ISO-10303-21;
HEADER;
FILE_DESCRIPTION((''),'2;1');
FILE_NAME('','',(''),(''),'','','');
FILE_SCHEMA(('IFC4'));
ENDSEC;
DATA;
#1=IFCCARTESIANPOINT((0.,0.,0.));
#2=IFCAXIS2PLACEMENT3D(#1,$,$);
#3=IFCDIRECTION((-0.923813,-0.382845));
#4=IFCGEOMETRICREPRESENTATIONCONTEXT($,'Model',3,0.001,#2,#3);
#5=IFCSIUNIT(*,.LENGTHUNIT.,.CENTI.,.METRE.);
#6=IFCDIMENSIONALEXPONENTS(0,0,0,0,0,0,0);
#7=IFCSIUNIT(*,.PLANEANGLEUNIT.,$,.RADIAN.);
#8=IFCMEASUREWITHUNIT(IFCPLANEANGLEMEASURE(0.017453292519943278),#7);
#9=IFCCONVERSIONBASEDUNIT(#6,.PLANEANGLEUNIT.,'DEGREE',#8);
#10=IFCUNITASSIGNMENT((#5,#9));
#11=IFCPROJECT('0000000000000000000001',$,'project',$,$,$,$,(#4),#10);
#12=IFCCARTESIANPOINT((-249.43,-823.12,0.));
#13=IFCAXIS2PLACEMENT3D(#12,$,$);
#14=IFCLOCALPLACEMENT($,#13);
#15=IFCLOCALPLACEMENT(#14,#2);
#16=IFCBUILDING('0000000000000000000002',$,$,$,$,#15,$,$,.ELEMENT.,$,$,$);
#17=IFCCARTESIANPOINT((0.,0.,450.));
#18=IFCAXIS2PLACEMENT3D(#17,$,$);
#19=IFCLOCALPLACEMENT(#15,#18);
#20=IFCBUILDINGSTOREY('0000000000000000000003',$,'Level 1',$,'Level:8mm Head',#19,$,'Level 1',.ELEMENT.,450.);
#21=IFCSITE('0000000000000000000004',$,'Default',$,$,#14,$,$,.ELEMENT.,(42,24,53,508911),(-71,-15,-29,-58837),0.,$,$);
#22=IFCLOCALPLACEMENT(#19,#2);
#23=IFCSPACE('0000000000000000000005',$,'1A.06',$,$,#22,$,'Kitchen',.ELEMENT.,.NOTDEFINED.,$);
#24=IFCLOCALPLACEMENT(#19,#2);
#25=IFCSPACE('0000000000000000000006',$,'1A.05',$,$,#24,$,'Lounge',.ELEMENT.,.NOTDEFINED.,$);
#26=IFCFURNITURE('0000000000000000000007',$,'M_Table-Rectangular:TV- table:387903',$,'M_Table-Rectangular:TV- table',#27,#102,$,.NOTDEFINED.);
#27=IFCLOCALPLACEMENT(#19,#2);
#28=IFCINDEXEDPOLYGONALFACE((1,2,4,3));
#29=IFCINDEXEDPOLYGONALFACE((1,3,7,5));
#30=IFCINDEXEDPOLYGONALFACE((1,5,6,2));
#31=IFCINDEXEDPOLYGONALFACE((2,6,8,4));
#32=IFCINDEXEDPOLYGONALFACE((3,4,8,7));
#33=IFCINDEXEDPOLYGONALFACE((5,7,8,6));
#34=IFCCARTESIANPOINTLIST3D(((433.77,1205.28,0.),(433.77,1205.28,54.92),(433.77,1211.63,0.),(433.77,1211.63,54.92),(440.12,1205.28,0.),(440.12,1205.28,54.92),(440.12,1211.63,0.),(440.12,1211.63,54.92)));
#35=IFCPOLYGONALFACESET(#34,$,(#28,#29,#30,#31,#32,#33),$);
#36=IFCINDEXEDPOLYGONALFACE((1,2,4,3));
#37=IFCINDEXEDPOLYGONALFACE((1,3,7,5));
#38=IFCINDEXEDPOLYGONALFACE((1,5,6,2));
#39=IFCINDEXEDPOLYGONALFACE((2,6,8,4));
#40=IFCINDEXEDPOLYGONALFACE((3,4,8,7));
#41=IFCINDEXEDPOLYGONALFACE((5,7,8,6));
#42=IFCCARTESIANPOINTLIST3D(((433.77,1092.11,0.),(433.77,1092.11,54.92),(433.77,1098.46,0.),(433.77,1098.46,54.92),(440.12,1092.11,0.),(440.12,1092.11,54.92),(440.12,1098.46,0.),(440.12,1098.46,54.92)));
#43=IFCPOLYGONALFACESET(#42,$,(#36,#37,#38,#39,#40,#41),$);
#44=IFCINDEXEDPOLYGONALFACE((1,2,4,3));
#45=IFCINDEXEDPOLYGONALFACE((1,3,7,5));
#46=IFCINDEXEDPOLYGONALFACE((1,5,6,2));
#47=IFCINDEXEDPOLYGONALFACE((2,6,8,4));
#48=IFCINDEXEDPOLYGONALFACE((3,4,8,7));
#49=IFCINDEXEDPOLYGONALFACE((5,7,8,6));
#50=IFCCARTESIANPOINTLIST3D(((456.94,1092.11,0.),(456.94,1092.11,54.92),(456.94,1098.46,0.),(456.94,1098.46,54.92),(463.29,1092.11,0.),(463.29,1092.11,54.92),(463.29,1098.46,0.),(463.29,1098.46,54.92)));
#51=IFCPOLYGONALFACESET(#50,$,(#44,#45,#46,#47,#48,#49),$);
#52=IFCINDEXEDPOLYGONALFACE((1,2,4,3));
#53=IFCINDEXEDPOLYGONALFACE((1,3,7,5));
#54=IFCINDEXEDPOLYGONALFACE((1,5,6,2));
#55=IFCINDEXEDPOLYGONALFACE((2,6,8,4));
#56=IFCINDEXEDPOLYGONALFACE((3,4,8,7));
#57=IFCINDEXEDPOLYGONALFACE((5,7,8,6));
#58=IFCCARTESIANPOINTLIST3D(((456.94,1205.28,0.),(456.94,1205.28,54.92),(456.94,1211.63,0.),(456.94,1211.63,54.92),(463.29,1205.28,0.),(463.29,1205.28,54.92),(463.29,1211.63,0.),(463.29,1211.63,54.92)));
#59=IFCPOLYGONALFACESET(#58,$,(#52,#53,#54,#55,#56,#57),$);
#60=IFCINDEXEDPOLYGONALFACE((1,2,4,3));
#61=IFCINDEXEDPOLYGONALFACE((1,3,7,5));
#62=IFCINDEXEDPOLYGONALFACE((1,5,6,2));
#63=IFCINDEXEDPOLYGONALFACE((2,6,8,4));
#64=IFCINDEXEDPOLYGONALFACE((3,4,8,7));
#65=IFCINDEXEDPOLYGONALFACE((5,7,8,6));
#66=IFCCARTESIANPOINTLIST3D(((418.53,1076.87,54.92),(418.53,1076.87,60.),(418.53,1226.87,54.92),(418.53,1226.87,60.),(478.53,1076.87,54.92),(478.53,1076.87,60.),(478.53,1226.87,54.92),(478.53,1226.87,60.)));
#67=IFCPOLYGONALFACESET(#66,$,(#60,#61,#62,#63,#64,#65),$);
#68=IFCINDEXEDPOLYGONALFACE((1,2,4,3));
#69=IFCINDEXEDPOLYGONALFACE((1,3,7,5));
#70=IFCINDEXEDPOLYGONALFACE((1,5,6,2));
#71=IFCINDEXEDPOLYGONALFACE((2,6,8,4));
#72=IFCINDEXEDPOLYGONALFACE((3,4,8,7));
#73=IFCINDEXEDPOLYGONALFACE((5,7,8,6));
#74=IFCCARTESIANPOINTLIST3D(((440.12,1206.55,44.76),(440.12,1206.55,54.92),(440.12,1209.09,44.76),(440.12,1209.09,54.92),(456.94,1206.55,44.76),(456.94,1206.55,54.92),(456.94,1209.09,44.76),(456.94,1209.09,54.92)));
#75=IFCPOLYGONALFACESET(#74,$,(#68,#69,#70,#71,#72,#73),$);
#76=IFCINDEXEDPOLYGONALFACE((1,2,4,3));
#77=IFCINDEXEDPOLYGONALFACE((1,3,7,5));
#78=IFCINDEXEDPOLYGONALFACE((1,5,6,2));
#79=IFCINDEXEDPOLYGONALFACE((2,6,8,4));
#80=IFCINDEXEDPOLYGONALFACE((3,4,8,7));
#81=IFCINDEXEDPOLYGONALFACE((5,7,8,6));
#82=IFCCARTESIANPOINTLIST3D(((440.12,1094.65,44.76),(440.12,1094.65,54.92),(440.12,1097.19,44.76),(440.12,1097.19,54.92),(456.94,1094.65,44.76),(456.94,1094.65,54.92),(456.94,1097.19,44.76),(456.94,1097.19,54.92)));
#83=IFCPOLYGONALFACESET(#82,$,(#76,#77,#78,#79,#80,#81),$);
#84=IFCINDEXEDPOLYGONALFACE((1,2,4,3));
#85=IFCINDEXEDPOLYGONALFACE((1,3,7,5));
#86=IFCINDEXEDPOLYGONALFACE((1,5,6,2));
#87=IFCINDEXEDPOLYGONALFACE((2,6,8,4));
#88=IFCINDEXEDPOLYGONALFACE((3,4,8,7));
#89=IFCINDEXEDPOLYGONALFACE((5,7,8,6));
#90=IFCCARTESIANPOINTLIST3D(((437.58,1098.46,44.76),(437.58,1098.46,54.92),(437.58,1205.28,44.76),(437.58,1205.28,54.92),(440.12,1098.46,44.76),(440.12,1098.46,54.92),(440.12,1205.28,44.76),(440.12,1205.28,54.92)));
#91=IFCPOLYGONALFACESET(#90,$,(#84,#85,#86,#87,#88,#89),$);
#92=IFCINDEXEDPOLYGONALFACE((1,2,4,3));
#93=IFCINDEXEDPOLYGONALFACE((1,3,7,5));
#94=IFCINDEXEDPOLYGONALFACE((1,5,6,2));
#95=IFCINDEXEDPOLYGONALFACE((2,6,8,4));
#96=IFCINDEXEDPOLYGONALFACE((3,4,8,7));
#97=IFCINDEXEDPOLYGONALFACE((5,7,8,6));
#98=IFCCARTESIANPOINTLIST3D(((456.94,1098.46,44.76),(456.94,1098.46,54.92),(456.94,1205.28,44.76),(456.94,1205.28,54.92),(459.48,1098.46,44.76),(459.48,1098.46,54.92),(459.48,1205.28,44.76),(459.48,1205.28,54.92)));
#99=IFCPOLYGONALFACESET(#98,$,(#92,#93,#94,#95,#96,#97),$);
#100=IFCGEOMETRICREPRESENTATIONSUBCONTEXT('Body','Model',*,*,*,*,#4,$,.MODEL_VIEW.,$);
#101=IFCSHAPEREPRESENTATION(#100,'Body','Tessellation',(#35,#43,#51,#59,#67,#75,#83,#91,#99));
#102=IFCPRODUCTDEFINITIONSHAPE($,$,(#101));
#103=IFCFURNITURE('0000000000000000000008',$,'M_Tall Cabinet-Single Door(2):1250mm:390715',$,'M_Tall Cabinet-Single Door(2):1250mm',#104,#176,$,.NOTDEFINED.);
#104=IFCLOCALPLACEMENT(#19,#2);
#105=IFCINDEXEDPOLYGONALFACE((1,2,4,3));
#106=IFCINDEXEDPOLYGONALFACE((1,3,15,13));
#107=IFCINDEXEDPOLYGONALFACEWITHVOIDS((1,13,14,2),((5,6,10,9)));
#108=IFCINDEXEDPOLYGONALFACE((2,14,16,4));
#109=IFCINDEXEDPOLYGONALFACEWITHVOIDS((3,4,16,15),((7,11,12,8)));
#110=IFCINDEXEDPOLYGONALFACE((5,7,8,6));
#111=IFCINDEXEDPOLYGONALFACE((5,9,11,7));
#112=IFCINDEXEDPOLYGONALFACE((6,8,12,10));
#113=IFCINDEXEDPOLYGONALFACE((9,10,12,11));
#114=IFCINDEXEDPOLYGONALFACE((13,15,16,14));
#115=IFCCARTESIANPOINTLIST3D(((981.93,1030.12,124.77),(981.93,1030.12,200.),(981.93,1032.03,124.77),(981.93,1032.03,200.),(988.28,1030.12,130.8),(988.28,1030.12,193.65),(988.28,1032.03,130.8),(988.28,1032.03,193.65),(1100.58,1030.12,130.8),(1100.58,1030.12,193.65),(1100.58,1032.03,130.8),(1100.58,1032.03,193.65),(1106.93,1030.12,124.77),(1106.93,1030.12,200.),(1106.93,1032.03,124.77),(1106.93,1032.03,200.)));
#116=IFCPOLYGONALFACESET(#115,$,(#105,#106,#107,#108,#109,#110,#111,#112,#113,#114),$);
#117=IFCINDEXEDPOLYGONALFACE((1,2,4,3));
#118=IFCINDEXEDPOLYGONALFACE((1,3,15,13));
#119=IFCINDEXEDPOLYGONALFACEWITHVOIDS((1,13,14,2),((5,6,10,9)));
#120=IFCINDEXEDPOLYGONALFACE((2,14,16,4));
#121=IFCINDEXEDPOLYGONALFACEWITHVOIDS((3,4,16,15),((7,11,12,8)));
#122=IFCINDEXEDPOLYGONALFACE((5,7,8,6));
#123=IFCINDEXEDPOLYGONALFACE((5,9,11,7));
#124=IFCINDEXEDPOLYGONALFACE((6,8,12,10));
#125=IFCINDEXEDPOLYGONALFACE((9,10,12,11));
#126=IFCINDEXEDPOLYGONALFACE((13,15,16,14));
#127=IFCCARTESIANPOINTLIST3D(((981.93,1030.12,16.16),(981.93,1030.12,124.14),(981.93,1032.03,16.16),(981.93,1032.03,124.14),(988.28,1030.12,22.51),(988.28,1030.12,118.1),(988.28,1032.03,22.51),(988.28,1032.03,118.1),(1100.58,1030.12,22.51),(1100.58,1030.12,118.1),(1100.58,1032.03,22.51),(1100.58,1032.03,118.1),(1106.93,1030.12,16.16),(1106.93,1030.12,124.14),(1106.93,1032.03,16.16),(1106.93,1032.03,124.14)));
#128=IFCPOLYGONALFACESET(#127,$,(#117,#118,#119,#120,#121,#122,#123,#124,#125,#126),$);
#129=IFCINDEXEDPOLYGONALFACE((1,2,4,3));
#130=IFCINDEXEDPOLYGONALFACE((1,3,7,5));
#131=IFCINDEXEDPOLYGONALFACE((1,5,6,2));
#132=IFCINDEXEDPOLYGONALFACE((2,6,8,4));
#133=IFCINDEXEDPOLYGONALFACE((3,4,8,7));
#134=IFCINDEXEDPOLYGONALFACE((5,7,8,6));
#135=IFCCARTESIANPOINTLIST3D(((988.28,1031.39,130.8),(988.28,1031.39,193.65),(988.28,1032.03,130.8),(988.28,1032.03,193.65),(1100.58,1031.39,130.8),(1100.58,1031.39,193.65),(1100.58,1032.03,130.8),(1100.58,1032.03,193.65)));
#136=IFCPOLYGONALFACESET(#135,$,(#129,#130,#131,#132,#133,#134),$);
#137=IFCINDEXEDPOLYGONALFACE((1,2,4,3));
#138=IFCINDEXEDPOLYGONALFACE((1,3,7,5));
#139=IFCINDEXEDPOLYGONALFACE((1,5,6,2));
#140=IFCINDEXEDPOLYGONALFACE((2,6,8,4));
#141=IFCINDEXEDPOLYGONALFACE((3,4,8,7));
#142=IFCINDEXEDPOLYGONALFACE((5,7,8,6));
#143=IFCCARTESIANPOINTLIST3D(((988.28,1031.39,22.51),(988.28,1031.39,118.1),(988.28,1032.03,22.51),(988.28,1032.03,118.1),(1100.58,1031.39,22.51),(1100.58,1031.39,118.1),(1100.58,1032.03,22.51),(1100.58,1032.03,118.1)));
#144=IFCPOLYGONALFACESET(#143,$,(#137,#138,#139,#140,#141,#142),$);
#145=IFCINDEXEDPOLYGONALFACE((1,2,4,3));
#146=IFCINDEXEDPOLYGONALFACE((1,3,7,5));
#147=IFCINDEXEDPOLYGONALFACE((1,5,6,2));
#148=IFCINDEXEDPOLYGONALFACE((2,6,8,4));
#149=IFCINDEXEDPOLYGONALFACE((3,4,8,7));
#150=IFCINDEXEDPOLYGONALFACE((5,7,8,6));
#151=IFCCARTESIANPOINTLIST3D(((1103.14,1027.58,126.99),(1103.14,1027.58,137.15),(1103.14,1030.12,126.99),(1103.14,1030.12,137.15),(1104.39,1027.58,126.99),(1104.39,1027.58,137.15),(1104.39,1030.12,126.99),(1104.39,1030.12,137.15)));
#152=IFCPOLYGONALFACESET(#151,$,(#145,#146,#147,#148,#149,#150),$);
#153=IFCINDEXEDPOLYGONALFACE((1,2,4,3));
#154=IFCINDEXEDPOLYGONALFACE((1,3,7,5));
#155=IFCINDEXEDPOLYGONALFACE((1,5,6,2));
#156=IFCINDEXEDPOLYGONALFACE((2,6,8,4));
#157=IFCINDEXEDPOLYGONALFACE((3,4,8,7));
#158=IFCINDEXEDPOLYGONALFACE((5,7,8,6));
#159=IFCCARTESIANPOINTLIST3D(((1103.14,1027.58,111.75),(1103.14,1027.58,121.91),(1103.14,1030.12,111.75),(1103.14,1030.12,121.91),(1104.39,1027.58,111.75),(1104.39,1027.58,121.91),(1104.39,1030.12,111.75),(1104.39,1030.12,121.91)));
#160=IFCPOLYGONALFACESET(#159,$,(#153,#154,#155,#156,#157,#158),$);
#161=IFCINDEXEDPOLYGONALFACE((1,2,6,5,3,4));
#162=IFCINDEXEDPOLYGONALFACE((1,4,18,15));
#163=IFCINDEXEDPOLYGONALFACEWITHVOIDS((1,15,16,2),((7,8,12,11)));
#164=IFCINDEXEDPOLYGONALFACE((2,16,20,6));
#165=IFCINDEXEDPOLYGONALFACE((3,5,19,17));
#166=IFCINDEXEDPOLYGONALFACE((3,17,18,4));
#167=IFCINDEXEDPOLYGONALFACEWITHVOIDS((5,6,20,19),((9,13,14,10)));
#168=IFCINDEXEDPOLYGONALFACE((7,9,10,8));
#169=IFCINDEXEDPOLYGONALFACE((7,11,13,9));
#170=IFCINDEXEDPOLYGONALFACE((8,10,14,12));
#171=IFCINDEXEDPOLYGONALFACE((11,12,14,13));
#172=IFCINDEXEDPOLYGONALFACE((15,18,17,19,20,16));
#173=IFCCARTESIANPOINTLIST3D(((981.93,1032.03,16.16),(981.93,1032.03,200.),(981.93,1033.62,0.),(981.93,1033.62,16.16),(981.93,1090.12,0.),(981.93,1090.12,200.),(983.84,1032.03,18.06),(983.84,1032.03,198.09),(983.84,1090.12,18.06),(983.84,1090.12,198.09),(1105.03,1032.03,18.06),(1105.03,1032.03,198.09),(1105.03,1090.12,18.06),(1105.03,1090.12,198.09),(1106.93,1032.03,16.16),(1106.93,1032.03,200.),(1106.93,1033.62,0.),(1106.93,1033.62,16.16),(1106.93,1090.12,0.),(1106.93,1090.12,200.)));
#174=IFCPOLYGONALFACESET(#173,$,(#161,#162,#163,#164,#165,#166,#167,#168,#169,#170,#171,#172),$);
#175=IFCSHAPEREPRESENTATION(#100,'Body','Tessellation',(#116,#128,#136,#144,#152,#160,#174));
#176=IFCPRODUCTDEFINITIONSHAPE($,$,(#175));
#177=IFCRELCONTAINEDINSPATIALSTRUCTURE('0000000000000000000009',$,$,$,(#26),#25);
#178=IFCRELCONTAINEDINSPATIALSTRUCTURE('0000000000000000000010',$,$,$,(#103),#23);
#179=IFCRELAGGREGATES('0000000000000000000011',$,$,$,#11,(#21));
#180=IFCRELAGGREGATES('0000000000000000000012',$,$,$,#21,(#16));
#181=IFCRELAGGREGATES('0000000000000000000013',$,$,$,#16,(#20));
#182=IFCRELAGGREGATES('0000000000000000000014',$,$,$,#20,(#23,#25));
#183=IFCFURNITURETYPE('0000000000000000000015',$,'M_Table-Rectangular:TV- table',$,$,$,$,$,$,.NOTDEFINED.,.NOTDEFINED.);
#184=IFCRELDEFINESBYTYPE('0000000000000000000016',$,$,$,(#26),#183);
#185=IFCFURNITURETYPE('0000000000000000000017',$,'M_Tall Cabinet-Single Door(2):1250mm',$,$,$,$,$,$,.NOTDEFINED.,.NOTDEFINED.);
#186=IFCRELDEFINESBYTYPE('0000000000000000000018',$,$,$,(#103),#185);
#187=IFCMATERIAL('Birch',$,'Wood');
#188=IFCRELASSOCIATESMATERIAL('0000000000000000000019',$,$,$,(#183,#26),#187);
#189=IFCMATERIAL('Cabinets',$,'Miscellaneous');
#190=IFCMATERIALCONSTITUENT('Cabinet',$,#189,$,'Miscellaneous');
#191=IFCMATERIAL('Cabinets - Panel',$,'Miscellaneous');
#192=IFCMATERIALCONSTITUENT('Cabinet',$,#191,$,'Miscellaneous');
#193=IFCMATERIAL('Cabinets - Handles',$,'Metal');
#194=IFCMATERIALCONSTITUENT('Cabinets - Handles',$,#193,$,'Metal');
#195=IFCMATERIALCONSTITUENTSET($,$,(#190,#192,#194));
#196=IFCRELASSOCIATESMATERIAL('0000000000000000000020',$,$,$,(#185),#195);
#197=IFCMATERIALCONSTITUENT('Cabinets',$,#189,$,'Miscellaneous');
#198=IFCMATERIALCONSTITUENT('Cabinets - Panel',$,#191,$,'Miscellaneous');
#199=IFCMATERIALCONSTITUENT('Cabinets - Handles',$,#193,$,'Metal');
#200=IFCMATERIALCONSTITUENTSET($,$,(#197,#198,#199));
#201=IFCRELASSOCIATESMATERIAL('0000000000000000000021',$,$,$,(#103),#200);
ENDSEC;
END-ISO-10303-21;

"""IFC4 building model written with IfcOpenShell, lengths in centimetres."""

from ifc_helpers import new_model, entity, si_unit, converted_unit, direction, frame, origin, place, context, subcontext, project, spatial, indexed_curve, outline, extrude, source, transform, mapped, material, constituent, constituent_set, type_object, type_shapes, element, save


model = new_model("IFC4")

# Units and contexts
model_context = context("Model", 3, precision=0.001, world=origin(), true_north=direction((-0.923813, -0.382845)))
body_context = subcontext(model_context, "Body", "Model", "MODEL_VIEW")
ifc_project = project(units=[si_unit("LENGTHUNIT", "METRE", prefix="CENTI"), converted_unit("PLANEANGLEUNIT", "DEGREE", entity("IfcPlaneAngleMeasure", 0.017453292519943278), si_unit("PLANEANGLEUNIT", "RADIAN"), dimensions=[0, 0, 0, 0, 0, 0, 0])], contexts=[model_context])

# Site, building, storey
site_placement = place(None, frame((-249.43, -823.12, 0.0)))
site = spatial("IfcSite", under=ifc_project, at=site_placement, Name="Default", CompositionType="ELEMENT", RefLatitude=(42, 24, 53, 508911), RefLongitude=(-71, -15, -29, -58837), RefElevation=0.0)
building_placement = place(site_placement, origin())
building = spatial("IfcBuilding", under=site, at=building_placement, CompositionType="ELEMENT")
storey_placement = place(building_placement, frame((0.0, 0.0, 450.0)))
storey = spatial("IfcBuildingStorey", under=building, at=storey_placement, Name="Level 1", ObjectType="Level:8mm Head", LongName="Level 1", CompositionType="ELEMENT", Elevation=450.0)

# Shared definitions
space_1_placement = place(storey_placement, origin())
space_1 = spatial("IfcSpace", under=storey, at=space_1_placement, Name="1A.06", LongName="Kitchen", CompositionType="ELEMENT", PredefinedType="NOTDEFINED")

# Shared definitions
space_2_placement = place(storey_placement, origin())
space_2 = spatial("IfcSpace", under=storey, at=space_2_placement, Name="1A.05", LongName="Lounge", CompositionType="ELEMENT", PredefinedType="NOTDEFINED")

# Furniture
ifc_material_1 = material(Name="Birch", Category="Wood")
furniture_type_1 = type_object("IfcFurnitureType", Name="M_Table-Rectangular:TV- table", AssemblyPlace="NOTDEFINED", PredefinedType="NOTDEFINED", material=ifc_material_1)
shared_shape_1 = source(origin(), body_context, "Body", "SweptSolid", [
    extrude(outline(indexed_curve([(-3.18, -3.18), (3.18, -3.18), (3.18, 3.18), (-3.18, 3.18), (-3.18, -3.18)], self_intersect=False)), frame((56.58, 11.59, 0.0), z_axis=(0.0, 0.0, 1.0), x_axis=(0.0, -1.0, 0.0)), (0.0, 0.0, 1.0), 54.92),
    extrude(outline(indexed_curve([(-3.17, -3.18), (3.17, -3.18), (3.17, 3.18), (-3.17, 3.18), (-3.17, -3.18)], self_intersect=False)), frame((-56.58, 11.59, 0.0), z_axis=(0.0, 0.0, 1.0), x_axis=(-1.0, 0.0, 0.0)), (0.0, 0.0, 1.0), 54.92),
    extrude(outline(indexed_curve([(-3.17, -3.17), (3.17, -3.17), (3.17, 3.17), (-3.17, 3.17), (-3.17, -3.17)], self_intersect=False)), frame((-56.58, -11.59, 0.0), z_axis=(0.0, 0.0, 1.0), x_axis=(0.0, 1.0, 0.0)), (0.0, 0.0, 1.0), 54.92),
    extrude(outline(indexed_curve([(-3.18, -3.17), (3.18, -3.17), (3.18, 3.17), (-3.18, 3.17), (-3.18, -3.17)], self_intersect=False)), frame((56.58, -11.59, 0.0)), (0.0, 0.0, 1.0), 54.92),
    extrude(outline(indexed_curve([(-75.0, -30.0), (75.0, -30.0), (75.0, 30.0), (-75.0, 30.0), (-75.0, -30.0)], self_intersect=False)), frame((0.0, 0.0, 54.92), z_axis=(0.0, 0.0, 1.0), x_axis=(-1.0, 0.0, 0.0)), (0.0, 0.0, 1.0), 5.08),
    extrude(outline(indexed_curve([(-1.27, -8.41), (1.27, -8.41), (1.27, 8.41), (-1.27, 8.41), (-1.27, -8.41)], self_intersect=False)), frame((55.95, 0.0, 44.76)), (0.0, 0.0, 1.0), 10.16),
    extrude(outline(indexed_curve([(-8.41, -1.27), (8.41, -1.27), (8.41, 1.27), (-8.41, 1.27), (-8.41, -1.27)], self_intersect=False)), frame((-55.95, 0.0, 44.76), z_axis=(0.0, 0.0, 1.0), x_axis=(0.0, 1.0, 0.0)), (0.0, 0.0, 1.0), 10.16),
    extrude(outline(indexed_curve([(-53.41, -1.27), (53.41, -1.27), (53.41, 1.27), (-53.41, 1.27), (-53.41, -1.27)], self_intersect=False)), frame((0.0, 9.68, 44.76), z_axis=(0.0, 0.0, 1.0), x_axis=(-1.0, 0.0, 0.0)), (0.0, 0.0, 1.0), 10.16),
    extrude(outline(indexed_curve([(-1.27, -53.41), (1.27, -53.41), (1.27, 53.41), (-1.27, 53.41), (-1.27, -53.41)], self_intersect=False)), frame((0.0, -9.68, 44.76), z_axis=(0.0, 0.0, 1.0), x_axis=(0.0, 1.0, 0.0)), (0.0, 0.0, 1.0), 10.16),
])
type_shapes(furniture_type_1, [shared_shape_1])
furniture_1_placement = place(space_2_placement, frame((448.53, 1151.87, 0.0), z_axis=(0.0, 0.0, 1.0), x_axis=(0.0, 1.0, 0.0)))
element("IfcFurniture", 1, at=furniture_1_placement, inside=space_2, type_object=furniture_type_1, material=ifc_material_1, Name="M_Table-Rectangular:TV- table:387903", ObjectType="M_Table-Rectangular:TV- table", PredefinedType="NOTDEFINED", context=body_context, shape_type="MappedRepresentation", body=[
    mapped(shared_shape_1, transform((0.0, 0.0, 0.0), scale=1.0)),
])

# Furniture, opening
ifc_material_2 = material(Name="Cabinets", Category="Miscellaneous")
ifc_constituent_1 = constituent(ifc_material_2, Name="Cabinets", Category="Miscellaneous")
ifc_material_3 = material(Name="Cabinets - Panel", Category="Miscellaneous")
ifc_constituent_2 = constituent(ifc_material_3, Name="Cabinets - Panel", Category="Miscellaneous")
ifc_material_4 = material(Name="Cabinets - Handles", Category="Metal")
ifc_constituent_3 = constituent(ifc_material_4, Name="Cabinets - Handles", Category="Metal")
ifc_constituent_set_1 = constituent_set(constituents=[ifc_constituent_1, ifc_constituent_2, ifc_constituent_3])
ifc_constituent_4 = constituent(ifc_material_2, Name="Cabinet", Category="Miscellaneous")
ifc_constituent_5 = constituent(ifc_material_3, Name="Cabinet", Category="Miscellaneous")
ifc_constituent_6 = constituent(ifc_material_4, Name="Cabinets - Handles", Category="Metal")
ifc_constituent_set_2 = constituent_set(constituents=[ifc_constituent_4, ifc_constituent_5, ifc_constituent_6])
furniture_type_2 = type_object("IfcFurnitureType", Name="M_Tall Cabinet-Single Door(2):1250mm", AssemblyPlace="NOTDEFINED", PredefinedType="NOTDEFINED", material=ifc_constituent_set_2)
shared_shape_2 = source(origin(), body_context, "Body", "SweptSolid", [
    extrude(outline(indexed_curve([(-0.95, -60.59), (0.95, -60.59), (0.95, 60.59), (-0.95, 60.59), (-0.95, -60.59)], self_intersect=False)), frame((1.87, -0.95, 18.06), z_axis=(0.0, 0.0, 1.0), x_axis=(0.0, 1.0, 0.0)), (0.0, 0.0, 1.0), 180.03),
    extrude(outline(indexed_curve([(-37.61, -62.5), (37.61, -62.5), (37.61, 62.5), (-37.61, 62.5), (-37.61, -62.5)], self_intersect=False), holes=[indexed_curve([(-31.26, -56.15), (-31.26, 56.15), (31.58, 56.15), (31.58, -56.15), (-31.26, -56.15)], self_intersect=False)]), frame((1.87, -60.0, 162.39), z_axis=(0.0, 1.0, 0.0), x_axis=(0.0, 0.0, -1.0)), (0.0, 0.0, 1.0), 1.91),
    extrude(outline(indexed_curve([(-62.5, -53.99), (62.5, -53.99), (62.5, 53.99), (-62.5, 53.99), (-62.5, -53.99)], self_intersect=False), holes=[indexed_curve([(-56.15, 47.96), (56.15, 47.96), (56.15, -47.64), (-56.15, -47.64), (-56.15, 47.96)], self_intersect=False)]), frame((1.87, -60.0, 70.15), z_axis=(0.0, 1.0, 0.0), x_axis=(-1.0, 0.0, 0.0)), (0.0, 0.0, 1.0), 1.91),
    extrude(outline(indexed_curve([(-0.32, -56.15), (0.32, -56.15), (0.32, 56.15), (-0.32, 56.15), (-0.32, -56.15)], self_intersect=False)), frame((1.87, -58.41, 130.8), z_axis=(0.0, 0.0, 1.0), x_axis=(0.0, 1.0, 0.0)), (0.0, 0.0, 1.0), 62.85),
    extrude(outline(indexed_curve([(-0.32, -56.15), (0.32, -56.15), (0.32, 56.15), (-0.32, 56.15), (-0.32, -56.15)], self_intersect=False)), frame((1.87, -58.41, 22.51), z_axis=(0.0, 0.0, 1.0), x_axis=(0.0, 1.0, 0.0)), (0.0, 0.0, 1.0), 95.6),
    extrude(outline(indexed_curve([(-1.27, -0.63), (1.27, -0.63), (1.27, 0.63), (-1.27, 0.63), (-1.27, -0.63)], self_intersect=False)), frame((61.21, -61.27, 126.99), z_axis=(0.0, 0.0, 1.0), x_axis=(0.0, 1.0, 0.0)), (0.0, 0.0, 1.0), 10.16),
    extrude(outline(indexed_curve([(-1.27, -0.63), (1.27, -0.63), (1.27, 0.63), (-1.27, 0.63), (-1.27, -0.63)], self_intersect=False)), frame((61.21, -61.27, 111.75), z_axis=(0.0, 0.0, 1.0), x_axis=(0.0, 1.0, 0.0)), (0.0, 0.0, 1.0), 10.16),
    extrude(outline(indexed_curve([(-19.9, 55.89), (-19.9, -127.95), (38.2, -127.95), (38.2, 72.05), (-18.3, 72.05), (-18.3, 55.89), (-19.9, 55.89)], self_intersect=False)), frame((-60.63, -38.2, 72.05), z_axis=(-1.0, 0.0, 0.0), x_axis=(0.0, 1.0, 0.0)), (0.0, 0.0, -1.0), 125.0),
])
type_shapes(furniture_type_2, [shared_shape_2])
furniture_2_placement = place(space_1_placement, frame((1042.56, 1090.12, 0.0)))
furniture_2 = element("IfcFurniture", 2, at=furniture_2_placement, inside=space_1, type_object=furniture_type_2, material=ifc_constituent_set_1, Name="M_Tall Cabinet-Single Door(2):1250mm:390715", ObjectType="M_Tall Cabinet-Single Door(2):1250mm", PredefinedType="NOTDEFINED", context=body_context, shape_type="MappedRepresentation", body=[
    mapped(shared_shape_2, transform((0.0, 0.0, 0.0), scale=1.0)),
])
opening_1_placement = place(storey_placement, frame((1042.56, 1090.12, 450.0)))
element("IfcOpeningElement", 3, at=opening_1_placement, cuts=furniture_2, PredefinedType="OPENING", context=body_context, shape_type="SweptSolid", body=[
    extrude(outline(indexed_curve([(-60.59, -90.02), (60.59, -90.02), (60.59, 90.02), (-60.59, 90.02), (-60.59, -90.02)], self_intersect=False)), frame((1.87, 0.0, -341.92), z_axis=(0.0, -1.0, 0.0), x_axis=(-1.0, 0.0, 0.0)), (0.0, 0.0, 1.0), 58.09),
])

save(model, "model.ifc")
